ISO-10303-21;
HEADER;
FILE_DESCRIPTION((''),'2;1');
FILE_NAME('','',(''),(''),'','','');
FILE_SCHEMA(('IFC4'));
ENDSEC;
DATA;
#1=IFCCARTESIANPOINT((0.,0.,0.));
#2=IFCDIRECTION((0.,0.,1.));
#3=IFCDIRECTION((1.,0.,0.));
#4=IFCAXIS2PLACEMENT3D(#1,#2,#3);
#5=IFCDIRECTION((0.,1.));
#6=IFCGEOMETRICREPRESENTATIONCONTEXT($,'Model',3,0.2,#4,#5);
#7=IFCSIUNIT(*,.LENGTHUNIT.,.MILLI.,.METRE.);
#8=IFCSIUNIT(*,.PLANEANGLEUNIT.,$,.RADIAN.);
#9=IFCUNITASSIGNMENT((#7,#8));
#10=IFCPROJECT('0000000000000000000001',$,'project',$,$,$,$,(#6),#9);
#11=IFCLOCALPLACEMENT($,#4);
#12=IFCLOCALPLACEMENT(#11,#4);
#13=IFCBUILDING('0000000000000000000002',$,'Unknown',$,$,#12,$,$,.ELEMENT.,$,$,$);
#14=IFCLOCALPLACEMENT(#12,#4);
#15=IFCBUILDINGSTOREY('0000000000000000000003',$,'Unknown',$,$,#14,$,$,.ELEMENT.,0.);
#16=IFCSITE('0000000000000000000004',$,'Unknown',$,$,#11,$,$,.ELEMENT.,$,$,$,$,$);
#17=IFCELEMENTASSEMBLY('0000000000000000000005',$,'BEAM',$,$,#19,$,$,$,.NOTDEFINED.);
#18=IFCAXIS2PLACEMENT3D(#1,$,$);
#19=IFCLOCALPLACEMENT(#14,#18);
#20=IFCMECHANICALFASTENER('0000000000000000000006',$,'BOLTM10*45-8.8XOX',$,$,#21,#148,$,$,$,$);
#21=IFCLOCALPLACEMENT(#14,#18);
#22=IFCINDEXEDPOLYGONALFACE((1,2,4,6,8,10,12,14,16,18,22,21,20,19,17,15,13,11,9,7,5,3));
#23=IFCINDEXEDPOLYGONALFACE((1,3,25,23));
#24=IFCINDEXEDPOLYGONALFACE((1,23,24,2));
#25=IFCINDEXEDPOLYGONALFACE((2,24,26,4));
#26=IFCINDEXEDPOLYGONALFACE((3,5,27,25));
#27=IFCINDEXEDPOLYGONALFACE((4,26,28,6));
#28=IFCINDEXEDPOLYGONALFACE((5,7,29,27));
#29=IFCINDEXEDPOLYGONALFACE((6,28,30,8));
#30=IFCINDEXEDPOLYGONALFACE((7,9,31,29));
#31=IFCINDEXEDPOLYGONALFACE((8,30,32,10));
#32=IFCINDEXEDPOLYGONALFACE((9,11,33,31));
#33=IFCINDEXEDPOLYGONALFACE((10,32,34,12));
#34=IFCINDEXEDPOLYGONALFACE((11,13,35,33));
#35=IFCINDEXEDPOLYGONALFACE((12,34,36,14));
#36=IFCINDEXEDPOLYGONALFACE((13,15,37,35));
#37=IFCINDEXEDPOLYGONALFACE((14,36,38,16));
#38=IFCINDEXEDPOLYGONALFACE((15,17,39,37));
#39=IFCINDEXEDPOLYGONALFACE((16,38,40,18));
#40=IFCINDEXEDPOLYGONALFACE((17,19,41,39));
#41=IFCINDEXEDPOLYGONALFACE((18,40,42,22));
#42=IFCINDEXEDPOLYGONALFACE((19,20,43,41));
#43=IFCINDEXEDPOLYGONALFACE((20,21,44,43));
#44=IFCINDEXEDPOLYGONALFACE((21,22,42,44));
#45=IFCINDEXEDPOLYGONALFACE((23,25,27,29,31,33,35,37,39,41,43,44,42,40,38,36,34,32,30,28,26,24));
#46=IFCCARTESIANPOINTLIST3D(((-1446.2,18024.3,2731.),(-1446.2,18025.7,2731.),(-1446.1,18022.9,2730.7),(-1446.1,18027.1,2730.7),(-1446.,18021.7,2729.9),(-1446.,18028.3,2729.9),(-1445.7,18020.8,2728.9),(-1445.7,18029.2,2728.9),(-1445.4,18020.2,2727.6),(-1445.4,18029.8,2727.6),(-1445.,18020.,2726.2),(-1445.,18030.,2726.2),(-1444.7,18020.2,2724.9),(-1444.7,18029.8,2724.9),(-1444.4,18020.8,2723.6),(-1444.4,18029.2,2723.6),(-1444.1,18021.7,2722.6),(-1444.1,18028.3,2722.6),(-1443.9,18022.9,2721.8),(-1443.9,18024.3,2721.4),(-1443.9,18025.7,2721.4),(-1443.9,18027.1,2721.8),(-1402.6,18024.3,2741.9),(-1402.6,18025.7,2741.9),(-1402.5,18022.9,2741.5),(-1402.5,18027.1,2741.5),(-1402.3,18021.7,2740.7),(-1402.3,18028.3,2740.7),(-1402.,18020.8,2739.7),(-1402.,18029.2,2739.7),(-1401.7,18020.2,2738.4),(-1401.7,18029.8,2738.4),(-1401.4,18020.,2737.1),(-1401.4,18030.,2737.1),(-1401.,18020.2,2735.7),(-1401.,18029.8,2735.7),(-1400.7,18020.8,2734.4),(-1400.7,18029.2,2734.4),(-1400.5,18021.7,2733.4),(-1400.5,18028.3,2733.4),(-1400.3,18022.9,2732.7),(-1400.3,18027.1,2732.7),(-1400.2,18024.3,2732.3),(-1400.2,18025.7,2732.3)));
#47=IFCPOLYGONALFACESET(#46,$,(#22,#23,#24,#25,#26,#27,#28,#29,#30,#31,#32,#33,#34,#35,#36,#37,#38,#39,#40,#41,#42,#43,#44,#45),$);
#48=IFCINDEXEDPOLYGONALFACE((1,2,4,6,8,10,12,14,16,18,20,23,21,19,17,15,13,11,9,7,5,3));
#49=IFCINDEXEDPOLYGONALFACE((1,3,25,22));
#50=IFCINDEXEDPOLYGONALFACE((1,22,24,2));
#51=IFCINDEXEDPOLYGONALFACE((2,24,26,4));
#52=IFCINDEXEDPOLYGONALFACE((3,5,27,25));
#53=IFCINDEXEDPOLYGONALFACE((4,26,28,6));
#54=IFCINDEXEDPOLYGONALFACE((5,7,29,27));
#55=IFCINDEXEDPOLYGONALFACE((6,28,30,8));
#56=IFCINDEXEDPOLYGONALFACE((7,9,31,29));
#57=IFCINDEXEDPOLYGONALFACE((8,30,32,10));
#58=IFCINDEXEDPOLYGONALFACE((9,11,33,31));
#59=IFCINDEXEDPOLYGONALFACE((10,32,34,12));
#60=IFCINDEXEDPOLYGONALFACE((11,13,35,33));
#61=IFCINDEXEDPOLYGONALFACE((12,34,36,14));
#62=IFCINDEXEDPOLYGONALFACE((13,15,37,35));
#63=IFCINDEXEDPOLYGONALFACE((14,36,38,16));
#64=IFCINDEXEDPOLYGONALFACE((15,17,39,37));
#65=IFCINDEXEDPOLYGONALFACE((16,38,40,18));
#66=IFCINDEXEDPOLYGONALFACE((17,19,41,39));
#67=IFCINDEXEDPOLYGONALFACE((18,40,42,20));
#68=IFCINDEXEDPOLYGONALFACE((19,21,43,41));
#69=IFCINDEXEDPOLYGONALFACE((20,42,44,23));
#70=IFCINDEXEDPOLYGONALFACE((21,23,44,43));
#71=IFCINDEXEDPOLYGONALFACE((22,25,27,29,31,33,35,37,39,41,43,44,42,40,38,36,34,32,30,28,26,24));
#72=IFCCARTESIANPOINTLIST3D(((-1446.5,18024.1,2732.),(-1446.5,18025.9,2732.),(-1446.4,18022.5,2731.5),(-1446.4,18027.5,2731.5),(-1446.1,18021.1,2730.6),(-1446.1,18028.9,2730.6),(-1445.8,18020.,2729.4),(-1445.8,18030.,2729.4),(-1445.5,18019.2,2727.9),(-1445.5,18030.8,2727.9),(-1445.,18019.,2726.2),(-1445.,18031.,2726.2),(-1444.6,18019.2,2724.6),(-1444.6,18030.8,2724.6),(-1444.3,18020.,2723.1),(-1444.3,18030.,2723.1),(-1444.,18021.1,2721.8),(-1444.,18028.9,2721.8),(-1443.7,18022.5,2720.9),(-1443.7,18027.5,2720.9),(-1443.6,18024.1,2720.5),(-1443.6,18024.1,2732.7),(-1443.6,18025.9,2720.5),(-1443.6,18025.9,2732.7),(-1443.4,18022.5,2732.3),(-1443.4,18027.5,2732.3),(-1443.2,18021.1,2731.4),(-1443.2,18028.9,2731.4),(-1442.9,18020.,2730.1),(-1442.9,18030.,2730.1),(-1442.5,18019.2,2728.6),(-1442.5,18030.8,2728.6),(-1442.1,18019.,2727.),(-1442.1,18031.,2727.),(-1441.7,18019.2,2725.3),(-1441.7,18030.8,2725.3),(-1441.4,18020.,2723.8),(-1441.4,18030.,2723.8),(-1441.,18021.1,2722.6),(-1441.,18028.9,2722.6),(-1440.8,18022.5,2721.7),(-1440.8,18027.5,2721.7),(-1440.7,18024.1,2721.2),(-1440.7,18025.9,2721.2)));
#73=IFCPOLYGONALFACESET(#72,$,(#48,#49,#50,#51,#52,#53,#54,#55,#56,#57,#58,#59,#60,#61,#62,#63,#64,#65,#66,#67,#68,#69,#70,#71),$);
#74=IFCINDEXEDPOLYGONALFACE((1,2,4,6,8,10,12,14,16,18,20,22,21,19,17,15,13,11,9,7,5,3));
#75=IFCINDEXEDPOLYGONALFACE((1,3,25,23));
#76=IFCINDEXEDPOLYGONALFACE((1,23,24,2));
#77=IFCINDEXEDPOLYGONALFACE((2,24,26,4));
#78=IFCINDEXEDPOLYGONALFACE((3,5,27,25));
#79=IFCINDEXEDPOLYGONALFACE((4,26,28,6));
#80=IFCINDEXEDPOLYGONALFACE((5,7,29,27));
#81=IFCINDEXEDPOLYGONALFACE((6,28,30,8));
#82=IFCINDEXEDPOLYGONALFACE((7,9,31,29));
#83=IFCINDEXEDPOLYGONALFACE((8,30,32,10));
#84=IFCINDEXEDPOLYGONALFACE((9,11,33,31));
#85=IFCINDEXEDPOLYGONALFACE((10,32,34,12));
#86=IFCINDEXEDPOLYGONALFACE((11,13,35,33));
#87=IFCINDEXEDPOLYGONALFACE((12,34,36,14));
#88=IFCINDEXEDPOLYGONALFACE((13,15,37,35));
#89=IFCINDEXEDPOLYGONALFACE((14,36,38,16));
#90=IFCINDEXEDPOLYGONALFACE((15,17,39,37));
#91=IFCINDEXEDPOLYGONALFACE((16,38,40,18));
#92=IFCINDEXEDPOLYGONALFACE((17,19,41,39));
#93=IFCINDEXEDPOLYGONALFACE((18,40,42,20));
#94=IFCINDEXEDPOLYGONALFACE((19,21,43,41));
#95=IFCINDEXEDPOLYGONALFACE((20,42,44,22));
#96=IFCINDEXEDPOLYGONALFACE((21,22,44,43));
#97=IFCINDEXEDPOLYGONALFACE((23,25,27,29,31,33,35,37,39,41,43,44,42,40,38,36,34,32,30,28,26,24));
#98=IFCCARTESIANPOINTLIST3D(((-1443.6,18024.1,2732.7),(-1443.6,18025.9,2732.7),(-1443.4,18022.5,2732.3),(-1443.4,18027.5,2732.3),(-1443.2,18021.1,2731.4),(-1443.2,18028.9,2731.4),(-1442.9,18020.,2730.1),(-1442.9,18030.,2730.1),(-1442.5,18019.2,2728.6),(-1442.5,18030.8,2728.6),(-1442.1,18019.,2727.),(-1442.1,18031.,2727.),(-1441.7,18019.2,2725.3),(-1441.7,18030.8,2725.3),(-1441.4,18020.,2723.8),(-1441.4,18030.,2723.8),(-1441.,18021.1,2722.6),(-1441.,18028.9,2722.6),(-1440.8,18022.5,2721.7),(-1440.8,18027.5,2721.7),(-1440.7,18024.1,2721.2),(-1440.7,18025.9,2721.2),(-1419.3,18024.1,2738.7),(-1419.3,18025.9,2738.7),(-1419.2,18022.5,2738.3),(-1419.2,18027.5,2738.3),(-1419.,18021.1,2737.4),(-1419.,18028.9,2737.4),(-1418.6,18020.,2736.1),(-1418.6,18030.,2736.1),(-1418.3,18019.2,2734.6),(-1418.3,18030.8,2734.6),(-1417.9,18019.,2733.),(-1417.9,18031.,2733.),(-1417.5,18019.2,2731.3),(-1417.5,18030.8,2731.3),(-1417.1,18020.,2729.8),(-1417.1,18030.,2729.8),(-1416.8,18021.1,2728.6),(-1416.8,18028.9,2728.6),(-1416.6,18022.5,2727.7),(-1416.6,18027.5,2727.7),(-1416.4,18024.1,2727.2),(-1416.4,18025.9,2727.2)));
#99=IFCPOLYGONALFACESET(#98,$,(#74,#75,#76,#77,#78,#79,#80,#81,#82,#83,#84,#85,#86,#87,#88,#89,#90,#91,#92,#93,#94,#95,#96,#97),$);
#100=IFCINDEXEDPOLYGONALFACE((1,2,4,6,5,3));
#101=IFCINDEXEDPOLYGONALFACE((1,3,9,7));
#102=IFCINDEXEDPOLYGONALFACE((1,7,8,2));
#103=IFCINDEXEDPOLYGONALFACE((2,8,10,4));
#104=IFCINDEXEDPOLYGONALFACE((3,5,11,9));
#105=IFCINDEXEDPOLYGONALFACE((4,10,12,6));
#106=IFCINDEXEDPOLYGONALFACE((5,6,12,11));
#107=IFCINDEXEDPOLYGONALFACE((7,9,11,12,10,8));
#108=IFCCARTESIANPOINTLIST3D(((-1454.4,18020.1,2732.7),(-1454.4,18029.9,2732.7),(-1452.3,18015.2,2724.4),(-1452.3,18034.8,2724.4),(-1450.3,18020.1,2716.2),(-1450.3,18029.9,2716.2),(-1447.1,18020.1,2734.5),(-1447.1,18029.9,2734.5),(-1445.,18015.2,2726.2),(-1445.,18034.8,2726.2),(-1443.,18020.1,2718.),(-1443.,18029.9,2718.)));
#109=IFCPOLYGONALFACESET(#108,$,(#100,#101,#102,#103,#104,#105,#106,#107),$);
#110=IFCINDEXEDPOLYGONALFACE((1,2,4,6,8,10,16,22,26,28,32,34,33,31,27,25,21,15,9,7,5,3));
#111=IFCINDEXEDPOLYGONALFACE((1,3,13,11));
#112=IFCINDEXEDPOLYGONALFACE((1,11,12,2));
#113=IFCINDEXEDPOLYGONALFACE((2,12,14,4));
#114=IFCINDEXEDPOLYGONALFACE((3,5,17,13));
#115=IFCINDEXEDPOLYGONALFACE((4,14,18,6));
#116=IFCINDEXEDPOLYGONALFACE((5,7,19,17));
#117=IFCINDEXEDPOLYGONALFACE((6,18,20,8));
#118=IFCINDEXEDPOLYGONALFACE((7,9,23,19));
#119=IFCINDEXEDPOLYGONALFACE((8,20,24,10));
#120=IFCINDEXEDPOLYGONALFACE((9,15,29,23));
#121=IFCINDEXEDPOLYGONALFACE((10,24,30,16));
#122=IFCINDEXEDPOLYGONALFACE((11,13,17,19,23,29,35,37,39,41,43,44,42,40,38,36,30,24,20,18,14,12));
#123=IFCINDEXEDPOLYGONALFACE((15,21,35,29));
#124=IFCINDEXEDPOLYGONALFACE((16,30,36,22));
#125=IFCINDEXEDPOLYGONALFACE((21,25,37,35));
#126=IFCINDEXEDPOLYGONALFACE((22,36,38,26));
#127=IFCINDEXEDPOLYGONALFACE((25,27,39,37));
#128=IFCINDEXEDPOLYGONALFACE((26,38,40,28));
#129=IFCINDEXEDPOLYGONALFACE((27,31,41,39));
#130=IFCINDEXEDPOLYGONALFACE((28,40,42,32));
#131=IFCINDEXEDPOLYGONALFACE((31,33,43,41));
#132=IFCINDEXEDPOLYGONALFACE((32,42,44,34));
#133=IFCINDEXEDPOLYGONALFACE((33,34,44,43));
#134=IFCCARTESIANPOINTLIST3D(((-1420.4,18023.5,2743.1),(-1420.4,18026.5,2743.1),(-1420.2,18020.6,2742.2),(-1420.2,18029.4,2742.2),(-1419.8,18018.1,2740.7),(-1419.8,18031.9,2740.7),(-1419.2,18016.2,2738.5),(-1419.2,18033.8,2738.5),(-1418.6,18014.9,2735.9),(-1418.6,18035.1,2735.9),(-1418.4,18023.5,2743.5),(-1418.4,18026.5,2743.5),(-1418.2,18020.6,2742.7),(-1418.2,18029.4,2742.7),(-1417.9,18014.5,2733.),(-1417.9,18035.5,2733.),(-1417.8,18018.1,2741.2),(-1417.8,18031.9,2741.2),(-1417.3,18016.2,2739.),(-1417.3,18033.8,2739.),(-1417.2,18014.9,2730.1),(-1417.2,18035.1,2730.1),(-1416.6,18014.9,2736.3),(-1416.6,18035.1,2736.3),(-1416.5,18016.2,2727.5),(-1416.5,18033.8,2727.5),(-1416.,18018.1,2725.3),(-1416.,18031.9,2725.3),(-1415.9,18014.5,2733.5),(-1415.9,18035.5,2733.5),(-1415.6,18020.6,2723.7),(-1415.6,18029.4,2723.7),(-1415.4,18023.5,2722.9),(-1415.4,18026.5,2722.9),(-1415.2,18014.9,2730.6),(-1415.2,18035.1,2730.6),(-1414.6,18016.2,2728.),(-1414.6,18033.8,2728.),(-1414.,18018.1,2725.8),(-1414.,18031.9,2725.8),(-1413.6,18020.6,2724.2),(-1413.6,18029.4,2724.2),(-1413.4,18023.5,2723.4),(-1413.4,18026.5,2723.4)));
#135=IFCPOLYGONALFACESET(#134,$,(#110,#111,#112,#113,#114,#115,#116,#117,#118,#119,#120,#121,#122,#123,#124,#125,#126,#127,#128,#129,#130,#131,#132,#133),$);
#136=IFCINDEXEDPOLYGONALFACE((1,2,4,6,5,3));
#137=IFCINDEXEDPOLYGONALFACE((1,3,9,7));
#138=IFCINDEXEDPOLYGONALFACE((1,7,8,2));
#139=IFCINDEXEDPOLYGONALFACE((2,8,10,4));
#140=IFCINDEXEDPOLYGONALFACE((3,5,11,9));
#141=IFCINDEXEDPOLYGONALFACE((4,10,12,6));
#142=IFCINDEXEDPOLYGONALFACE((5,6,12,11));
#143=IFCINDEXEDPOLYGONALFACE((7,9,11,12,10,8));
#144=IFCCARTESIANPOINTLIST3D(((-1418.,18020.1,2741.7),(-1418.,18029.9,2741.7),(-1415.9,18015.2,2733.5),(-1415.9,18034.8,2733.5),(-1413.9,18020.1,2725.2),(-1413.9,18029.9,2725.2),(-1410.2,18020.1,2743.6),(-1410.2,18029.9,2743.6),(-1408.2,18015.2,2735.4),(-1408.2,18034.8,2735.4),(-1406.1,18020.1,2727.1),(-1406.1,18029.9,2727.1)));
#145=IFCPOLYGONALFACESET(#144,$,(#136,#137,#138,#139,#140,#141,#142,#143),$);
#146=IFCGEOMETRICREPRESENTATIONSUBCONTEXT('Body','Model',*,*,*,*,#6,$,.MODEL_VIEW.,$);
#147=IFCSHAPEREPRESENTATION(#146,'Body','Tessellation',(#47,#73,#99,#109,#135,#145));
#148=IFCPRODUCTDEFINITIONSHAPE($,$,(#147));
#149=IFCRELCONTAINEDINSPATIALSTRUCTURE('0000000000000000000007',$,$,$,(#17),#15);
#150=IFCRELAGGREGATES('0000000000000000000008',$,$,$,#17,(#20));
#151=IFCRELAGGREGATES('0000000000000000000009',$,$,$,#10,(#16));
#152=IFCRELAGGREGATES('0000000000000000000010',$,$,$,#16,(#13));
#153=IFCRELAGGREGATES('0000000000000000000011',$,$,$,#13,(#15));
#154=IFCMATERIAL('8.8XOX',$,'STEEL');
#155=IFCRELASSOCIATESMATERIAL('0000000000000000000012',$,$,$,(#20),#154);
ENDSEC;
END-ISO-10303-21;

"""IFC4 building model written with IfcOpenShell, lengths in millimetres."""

from ifc_helpers import new_model, si_unit, direction, frame, origin_with_axes, place, context, subcontext, project, spatial, line, arc, indexed_curve, outline, extrude, source, transform, mapped, material, element, aggregate, save


model = new_model("IFC4")

# Units and contexts
model_context = context("Model", 3, precision=0.2, world=origin_with_axes(), true_north=direction((0.0, 1.0)))
body_context = subcontext(model_context, "Body", "Model", "MODEL_VIEW")
ifc_project = project(units=[si_unit("LENGTHUNIT", "METRE", prefix="MILLI"), si_unit("PLANEANGLEUNIT", "RADIAN")], contexts=[model_context])

# Site, building, storey
site_placement = place(None, origin_with_axes())
site = spatial("IfcSite", under=ifc_project, at=site_placement, Name="Unknown", CompositionType="ELEMENT")
building_placement = place(site_placement, origin_with_axes())
building = spatial("IfcBuilding", under=site, at=building_placement, Name="Unknown", CompositionType="ELEMENT")
storey_placement = place(building_placement, origin_with_axes())
storey = spatial("IfcBuildingStorey", under=building, at=storey_placement, Name="Unknown", CompositionType="ELEMENT", Elevation=0.0)

# Element assembly, mechanical fastener
assembly_1_placement = place(storey_placement, frame((-1431.2, 18000.0, 2734.8), z_axis=(0.970613, 0.0, 0.240648), x_axis=(0.0, 1.0, 0.0)))
assembly_1 = element("IfcElementAssembly", 1, at=assembly_1_placement, inside=storey, Name="BEAM", PredefinedType="NOTDEFINED")
ifc_material_1 = material(Name="8.8XOX", Category="STEEL")
shared_shape_1 = source(origin_with_axes(), body_context, "Body", "SweptSolid", [
    extrude(outline(indexed_curve([(5.0, 0.0), (0.0, 5.0), (-5.0, 0.0), (0.0, -5.0)], segments=[arc(1, 2, 3), arc(3, 4, 1)])), frame((0.0, 0.0, 3.8), z_axis=(0.0, 0.0, -1.0), x_axis=(0.0, 1.0, 0.0)), (0.0, 0.0, 1.0), 45.0),
    extrude(outline(indexed_curve([(6.0, 0.0), (0.0, 6.0), (-6.0, 0.0), (0.0, -6.0)], segments=[arc(1, 2, 3), arc(3, 4, 1)])), frame((0.0, 0.0, 3.8), z_axis=(0.0, 0.0, -1.0), x_axis=(0.0, 1.0, 0.0)), (0.0, 0.0, 1.0), 3.0),
    extrude(outline(indexed_curve([(6.0, 0.0), (0.0, 6.0), (-6.0, 0.0), (0.0, -6.0)], segments=[arc(1, 2, 3), arc(3, 4, 1)])), frame((0.0, 0.0, 0.8), z_axis=(0.0, 0.0, -1.0), x_axis=(0.0, 1.0, 0.0)), (0.0, 0.0, 1.0), 25.0),
    extrude(outline(indexed_curve([(9.8, 0.0), (4.9, 8.5), (-4.9, 8.5), (-9.8, 0.0), (-4.9, -8.5), (4.9, -8.5)], segments=[line(1, 2, 3, 4, 5, 6, 1)])), frame((0.0, 0.0, 11.2), z_axis=(0.0, 0.0, -1.0), x_axis=(0.0, 1.0, 0.0)), (0.0, 0.0, 1.0), 7.5),
    extrude(outline(indexed_curve([(10.5, 0.0), (0.0, 10.5), (-10.5, 0.0), (0.0, -10.5)], segments=[arc(1, 2, 3), arc(3, 4, 1)])), frame((0.0, 0.0, -24.2), z_axis=(0.0, 0.0, -1.0), x_axis=(0.0, 1.0, 0.0)), (0.0, 0.0, 1.0), 2.0),
    extrude(outline(indexed_curve([(9.8, 0.0), (4.9, 8.5), (-4.9, 8.5), (-9.8, 0.0), (-4.9, -8.5), (4.9, -8.5)], segments=[line(1, 2, 3, 4, 5, 6, 1)])), frame((0.0, 0.0, -26.2), z_axis=(0.0, 0.0, -1.0), x_axis=(0.0, 1.0, 0.0)), (0.0, 0.0, 1.0), 8.0),
])
mechanical_fastener_1_placement = place(assembly_1_placement, frame((25.0, -5.0, -11.8), z_axis=(0.0, 0.0, -1.0), x_axis=(0.0, 1.0, 0.0)))
mechanical_fastener_1 = element("IfcMechanicalFastener", 2, at=mechanical_fastener_1_placement, material=ifc_material_1, Name="BOLTM10*45-8.8XOX", context=body_context, shape_type="MappedRepresentation", body=[
    mapped(shared_shape_1, transform((0.0, 0.0, 0.0))),
])
aggregate(assembly_1, [mechanical_fastener_1])

save(model, "model.ifc")
